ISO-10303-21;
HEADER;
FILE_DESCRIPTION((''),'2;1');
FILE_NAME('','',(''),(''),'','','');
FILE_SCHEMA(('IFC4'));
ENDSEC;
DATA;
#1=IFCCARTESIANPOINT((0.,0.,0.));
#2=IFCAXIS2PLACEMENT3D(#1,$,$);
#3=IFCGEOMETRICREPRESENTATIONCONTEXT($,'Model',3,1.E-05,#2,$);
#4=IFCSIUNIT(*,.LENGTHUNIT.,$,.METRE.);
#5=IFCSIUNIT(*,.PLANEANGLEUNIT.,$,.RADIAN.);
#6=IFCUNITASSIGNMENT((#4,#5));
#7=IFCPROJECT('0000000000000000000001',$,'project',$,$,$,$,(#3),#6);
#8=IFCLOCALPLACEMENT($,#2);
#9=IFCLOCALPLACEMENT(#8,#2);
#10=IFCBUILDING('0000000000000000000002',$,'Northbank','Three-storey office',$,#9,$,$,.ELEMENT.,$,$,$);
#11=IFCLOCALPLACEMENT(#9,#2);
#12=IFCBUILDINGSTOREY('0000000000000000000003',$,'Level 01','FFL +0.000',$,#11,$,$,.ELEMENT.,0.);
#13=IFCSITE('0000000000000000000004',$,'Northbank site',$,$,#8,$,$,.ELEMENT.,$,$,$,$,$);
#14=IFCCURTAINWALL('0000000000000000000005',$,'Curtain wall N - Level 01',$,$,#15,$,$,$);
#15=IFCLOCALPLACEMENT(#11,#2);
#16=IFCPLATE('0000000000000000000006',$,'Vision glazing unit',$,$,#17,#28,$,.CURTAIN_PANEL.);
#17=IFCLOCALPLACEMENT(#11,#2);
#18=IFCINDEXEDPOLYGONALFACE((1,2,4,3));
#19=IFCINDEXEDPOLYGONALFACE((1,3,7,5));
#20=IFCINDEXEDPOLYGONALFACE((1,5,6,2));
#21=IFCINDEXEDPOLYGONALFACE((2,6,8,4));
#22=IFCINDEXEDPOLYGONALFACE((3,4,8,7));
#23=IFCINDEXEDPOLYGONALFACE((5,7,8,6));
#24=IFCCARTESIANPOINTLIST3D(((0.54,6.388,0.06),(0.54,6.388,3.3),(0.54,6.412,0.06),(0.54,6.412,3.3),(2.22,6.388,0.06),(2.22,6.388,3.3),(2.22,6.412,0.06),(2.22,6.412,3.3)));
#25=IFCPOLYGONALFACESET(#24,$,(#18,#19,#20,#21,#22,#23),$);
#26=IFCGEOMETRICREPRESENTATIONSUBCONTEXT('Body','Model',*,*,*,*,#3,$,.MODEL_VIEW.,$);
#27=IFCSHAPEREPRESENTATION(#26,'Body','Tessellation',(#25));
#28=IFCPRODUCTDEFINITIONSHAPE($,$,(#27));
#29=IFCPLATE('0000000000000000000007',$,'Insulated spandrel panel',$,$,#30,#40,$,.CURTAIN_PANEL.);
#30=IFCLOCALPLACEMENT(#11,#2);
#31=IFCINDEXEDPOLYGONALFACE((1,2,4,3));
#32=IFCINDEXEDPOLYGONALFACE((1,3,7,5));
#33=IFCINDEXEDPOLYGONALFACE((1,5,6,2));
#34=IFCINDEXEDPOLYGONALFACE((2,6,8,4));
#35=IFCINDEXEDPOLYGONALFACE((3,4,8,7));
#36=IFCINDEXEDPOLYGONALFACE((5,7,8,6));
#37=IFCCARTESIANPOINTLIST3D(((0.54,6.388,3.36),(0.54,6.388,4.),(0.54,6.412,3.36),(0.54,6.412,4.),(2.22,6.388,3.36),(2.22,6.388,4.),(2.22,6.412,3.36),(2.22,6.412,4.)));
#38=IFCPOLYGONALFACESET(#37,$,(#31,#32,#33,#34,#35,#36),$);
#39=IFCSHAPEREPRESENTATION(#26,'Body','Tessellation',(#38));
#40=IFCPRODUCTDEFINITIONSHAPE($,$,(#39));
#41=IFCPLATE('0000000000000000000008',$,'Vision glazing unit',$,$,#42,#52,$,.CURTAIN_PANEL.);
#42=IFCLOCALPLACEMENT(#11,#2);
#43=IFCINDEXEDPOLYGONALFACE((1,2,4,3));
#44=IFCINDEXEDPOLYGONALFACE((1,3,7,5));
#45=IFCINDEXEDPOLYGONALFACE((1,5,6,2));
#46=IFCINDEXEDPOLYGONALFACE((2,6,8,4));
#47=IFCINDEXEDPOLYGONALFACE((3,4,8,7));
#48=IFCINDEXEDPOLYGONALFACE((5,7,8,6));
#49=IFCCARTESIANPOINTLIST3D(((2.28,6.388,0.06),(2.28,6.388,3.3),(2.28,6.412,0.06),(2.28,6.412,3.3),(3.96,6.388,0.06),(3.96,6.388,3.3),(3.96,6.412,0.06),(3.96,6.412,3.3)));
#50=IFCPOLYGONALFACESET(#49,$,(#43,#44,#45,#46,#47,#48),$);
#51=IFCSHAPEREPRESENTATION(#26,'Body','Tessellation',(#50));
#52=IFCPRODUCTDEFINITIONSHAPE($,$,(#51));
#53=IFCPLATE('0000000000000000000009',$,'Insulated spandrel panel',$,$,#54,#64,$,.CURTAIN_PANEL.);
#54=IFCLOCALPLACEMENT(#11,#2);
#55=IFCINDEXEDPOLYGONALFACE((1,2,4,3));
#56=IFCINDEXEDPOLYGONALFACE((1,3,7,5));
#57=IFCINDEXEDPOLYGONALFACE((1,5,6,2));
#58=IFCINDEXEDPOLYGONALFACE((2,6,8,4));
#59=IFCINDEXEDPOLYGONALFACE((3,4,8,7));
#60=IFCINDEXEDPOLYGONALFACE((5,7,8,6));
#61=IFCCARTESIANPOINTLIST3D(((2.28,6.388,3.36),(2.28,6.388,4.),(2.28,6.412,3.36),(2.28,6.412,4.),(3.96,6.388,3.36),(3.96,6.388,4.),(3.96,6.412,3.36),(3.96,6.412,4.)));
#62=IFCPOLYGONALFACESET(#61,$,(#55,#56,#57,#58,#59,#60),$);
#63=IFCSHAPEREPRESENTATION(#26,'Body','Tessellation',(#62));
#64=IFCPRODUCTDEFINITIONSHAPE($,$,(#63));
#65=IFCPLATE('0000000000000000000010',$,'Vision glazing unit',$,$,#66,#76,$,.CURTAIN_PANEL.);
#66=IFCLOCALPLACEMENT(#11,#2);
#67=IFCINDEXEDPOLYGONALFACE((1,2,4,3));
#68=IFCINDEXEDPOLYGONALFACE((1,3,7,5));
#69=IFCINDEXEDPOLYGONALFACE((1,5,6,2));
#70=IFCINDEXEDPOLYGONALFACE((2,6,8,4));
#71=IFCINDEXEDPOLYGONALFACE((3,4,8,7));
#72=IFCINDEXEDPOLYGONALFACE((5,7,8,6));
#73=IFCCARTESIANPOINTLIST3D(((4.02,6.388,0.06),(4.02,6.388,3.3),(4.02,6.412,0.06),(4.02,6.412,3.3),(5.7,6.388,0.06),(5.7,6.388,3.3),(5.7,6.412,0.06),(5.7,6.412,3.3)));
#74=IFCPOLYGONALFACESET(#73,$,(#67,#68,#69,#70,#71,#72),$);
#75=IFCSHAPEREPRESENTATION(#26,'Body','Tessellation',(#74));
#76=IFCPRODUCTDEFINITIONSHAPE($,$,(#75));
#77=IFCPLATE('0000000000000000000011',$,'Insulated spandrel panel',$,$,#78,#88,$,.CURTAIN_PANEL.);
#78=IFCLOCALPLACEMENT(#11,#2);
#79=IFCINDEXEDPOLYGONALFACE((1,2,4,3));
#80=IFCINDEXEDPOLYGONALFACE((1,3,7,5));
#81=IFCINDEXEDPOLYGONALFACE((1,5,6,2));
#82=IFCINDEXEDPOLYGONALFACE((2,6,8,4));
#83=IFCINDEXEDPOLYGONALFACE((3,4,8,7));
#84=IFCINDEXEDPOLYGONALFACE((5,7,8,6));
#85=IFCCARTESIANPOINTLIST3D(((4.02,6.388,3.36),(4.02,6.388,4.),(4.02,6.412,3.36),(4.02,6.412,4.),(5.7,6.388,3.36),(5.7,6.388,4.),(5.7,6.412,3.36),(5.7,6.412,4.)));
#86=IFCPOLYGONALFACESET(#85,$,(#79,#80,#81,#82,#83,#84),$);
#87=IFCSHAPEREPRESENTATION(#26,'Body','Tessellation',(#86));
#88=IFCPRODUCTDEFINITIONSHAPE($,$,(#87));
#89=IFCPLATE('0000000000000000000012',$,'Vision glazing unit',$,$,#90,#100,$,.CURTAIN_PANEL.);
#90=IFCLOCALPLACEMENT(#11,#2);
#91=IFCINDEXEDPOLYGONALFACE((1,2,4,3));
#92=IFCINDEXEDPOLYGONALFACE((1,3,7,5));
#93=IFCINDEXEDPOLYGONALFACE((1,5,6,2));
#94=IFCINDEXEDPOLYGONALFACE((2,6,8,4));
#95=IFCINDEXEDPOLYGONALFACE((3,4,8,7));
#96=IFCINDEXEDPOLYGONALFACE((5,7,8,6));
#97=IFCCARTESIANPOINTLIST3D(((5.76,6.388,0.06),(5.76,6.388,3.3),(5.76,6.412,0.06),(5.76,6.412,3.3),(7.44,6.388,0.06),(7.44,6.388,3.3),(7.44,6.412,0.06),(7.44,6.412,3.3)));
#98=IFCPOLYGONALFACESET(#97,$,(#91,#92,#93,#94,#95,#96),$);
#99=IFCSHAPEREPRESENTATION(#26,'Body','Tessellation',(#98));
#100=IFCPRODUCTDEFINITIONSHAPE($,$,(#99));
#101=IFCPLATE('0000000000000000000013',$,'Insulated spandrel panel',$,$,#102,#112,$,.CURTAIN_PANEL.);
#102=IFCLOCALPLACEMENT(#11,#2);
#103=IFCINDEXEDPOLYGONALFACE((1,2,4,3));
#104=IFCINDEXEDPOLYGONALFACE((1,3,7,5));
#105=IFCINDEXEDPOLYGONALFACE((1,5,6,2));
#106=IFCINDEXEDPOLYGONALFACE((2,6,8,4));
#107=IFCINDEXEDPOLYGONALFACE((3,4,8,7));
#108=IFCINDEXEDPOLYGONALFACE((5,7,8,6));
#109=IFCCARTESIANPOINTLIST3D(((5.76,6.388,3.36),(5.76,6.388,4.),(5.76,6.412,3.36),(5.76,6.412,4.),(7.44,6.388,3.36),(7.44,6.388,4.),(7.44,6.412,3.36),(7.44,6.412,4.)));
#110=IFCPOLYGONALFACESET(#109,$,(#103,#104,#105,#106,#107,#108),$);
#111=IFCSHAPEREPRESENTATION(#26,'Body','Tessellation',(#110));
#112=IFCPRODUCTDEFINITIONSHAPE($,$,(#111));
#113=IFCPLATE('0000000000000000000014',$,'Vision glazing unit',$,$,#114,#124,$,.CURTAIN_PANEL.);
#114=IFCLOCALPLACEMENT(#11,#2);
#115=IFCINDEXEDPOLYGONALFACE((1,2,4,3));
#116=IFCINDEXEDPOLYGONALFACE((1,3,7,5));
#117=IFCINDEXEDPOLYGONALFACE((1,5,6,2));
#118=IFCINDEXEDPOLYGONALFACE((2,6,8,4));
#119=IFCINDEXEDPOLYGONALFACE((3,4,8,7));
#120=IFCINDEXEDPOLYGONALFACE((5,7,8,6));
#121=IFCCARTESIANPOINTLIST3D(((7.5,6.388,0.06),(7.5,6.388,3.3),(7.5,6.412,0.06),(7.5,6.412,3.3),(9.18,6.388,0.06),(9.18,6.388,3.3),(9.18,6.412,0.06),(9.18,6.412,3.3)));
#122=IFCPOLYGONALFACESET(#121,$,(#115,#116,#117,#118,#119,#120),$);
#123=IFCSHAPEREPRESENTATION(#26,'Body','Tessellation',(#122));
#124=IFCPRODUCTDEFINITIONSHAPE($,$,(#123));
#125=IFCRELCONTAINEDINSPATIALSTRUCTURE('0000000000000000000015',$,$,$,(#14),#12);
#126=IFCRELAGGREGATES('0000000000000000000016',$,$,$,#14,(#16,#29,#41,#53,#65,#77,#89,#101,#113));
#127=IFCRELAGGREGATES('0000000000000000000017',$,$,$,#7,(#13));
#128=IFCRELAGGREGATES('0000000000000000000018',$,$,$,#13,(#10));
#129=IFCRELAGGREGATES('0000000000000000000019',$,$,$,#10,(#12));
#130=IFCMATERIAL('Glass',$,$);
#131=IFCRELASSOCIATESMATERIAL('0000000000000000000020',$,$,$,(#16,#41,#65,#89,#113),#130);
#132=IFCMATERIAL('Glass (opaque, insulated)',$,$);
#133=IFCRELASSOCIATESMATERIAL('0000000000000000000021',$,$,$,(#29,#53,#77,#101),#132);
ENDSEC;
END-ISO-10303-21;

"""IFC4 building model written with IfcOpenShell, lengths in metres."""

from ifc_helpers import new_model, si_unit, frame, origin, place, context, subcontext, project, spatial, rectangle, extrude, material, element, aggregate, save


model = new_model("IFC4")

# Units and contexts
model_context = context("Model", 3, precision=1e-05, world=origin())
body_context = subcontext(model_context, "Body", "Model", "MODEL_VIEW")
ifc_project = project(units=[si_unit("LENGTHUNIT", "METRE"), si_unit("PLANEANGLEUNIT", "RADIAN")], contexts=[model_context])

# Site, building, storey
site_placement = place(None, origin())
site = spatial("IfcSite", under=ifc_project, at=site_placement, Name="Northbank site", CompositionType="ELEMENT")
building_placement = place(site_placement, origin())
building = spatial("IfcBuilding", under=site, at=building_placement, Name="Northbank", Description="Three-storey office", CompositionType="ELEMENT")
storey_placement = place(building_placement, origin())
storey = spatial("IfcBuildingStorey", under=building, at=storey_placement, Name="Level 01", Description="FFL +0.000", CompositionType="ELEMENT", Elevation=0.0)

# Curtain wall, plates
curtain_wall_placement = place(storey_placement, origin())
curtain_wall = element("IfcCurtainWall", 1, at=curtain_wall_placement, inside=storey, Name="Curtain wall N - Level 01")
ifc_material_1 = material(Name="Glass")
ifc_material_2 = material(Name="Glass (opaque, insulated)")
plate_1_placement = place(storey_placement, origin())
plate_1 = element("IfcPlate", 2, at=plate_1_placement, material=ifc_material_1, Name="Vision glazing unit", PredefinedType="CURTAIN_PANEL", context=body_context, shape_type="SweptSolid", body=[
    extrude(rectangle(XDim=1.68, YDim=0.024), frame((1.38, 6.4, 0.06)), (0.0, 0.0, 1.0), 3.24),
])
plate_2_placement = place(storey_placement, origin())
plate_2 = element("IfcPlate", 3, at=plate_2_placement, material=ifc_material_2, Name="Insulated spandrel panel", PredefinedType="CURTAIN_PANEL", context=body_context, shape_type="SweptSolid", body=[
    extrude(rectangle(XDim=1.68, YDim=0.024), frame((1.38, 6.4, 3.36)), (0.0, 0.0, 1.0), 0.64),
])
plate_3_placement = place(storey_placement, origin())
plate_3 = element("IfcPlate", 4, at=plate_3_placement, material=ifc_material_1, Name="Vision glazing unit", PredefinedType="CURTAIN_PANEL", context=body_context, shape_type="SweptSolid", body=[
    extrude(rectangle(XDim=1.68, YDim=0.024), frame((3.12, 6.4, 0.06)), (0.0, 0.0, 1.0), 3.24),
])
plate_4_placement = place(storey_placement, origin())
plate_4 = element("IfcPlate", 5, at=plate_4_placement, material=ifc_material_2, Name="Insulated spandrel panel", PredefinedType="CURTAIN_PANEL", context=body_context, shape_type="SweptSolid", body=[
    extrude(rectangle(XDim=1.68, YDim=0.024), frame((3.12, 6.4, 3.36)), (0.0, 0.0, 1.0), 0.64),
])
plate_5_placement = place(storey_placement, origin())
plate_5 = element("IfcPlate", 6, at=plate_5_placement, material=ifc_material_1, Name="Vision glazing unit", PredefinedType="CURTAIN_PANEL", context=body_context, shape_type="SweptSolid", body=[
    extrude(rectangle(XDim=1.68, YDim=0.024), frame((4.86, 6.4, 0.06)), (0.0, 0.0, 1.0), 3.24),
])
plate_6_placement = place(storey_placement, origin())
plate_6 = element("IfcPlate", 7, at=plate_6_placement, material=ifc_material_2, Name="Insulated spandrel panel", PredefinedType="CURTAIN_PANEL", context=body_context, shape_type="SweptSolid", body=[
    extrude(rectangle(XDim=1.68, YDim=0.024), frame((4.86, 6.4, 3.36)), (0.0, 0.0, 1.0), 0.64),
])
plate_7_placement = place(storey_placement, origin())
plate_7 = element("IfcPlate", 8, at=plate_7_placement, material=ifc_material_1, Name="Vision glazing unit", PredefinedType="CURTAIN_PANEL", context=body_context, shape_type="SweptSolid", body=[
    extrude(rectangle(XDim=1.68, YDim=0.024), frame((6.6, 6.4, 0.06)), (0.0, 0.0, 1.0), 3.24),
])
plate_8_placement = place(storey_placement, origin())
plate_8 = element("IfcPlate", 9, at=plate_8_placement, material=ifc_material_2, Name="Insulated spandrel panel", PredefinedType="CURTAIN_PANEL", context=body_context, shape_type="SweptSolid", body=[
    extrude(rectangle(XDim=1.68, YDim=0.024), frame((6.6, 6.4, 3.36)), (0.0, 0.0, 1.0), 0.64),
])
plate_9_placement = place(storey_placement, origin())
plate_9 = element("IfcPlate", 10, at=plate_9_placement, material=ifc_material_1, Name="Vision glazing unit", PredefinedType="CURTAIN_PANEL", context=body_context, shape_type="SweptSolid", body=[
    extrude(rectangle(XDim=1.68, YDim=0.024), frame((8.34, 6.4, 0.06)), (0.0, 0.0, 1.0), 3.24),
])
aggregate(curtain_wall, [plate_1, plate_2, plate_3, plate_4, plate_5, plate_6, plate_7, plate_8, plate_9])

save(model, "model.ifc")
